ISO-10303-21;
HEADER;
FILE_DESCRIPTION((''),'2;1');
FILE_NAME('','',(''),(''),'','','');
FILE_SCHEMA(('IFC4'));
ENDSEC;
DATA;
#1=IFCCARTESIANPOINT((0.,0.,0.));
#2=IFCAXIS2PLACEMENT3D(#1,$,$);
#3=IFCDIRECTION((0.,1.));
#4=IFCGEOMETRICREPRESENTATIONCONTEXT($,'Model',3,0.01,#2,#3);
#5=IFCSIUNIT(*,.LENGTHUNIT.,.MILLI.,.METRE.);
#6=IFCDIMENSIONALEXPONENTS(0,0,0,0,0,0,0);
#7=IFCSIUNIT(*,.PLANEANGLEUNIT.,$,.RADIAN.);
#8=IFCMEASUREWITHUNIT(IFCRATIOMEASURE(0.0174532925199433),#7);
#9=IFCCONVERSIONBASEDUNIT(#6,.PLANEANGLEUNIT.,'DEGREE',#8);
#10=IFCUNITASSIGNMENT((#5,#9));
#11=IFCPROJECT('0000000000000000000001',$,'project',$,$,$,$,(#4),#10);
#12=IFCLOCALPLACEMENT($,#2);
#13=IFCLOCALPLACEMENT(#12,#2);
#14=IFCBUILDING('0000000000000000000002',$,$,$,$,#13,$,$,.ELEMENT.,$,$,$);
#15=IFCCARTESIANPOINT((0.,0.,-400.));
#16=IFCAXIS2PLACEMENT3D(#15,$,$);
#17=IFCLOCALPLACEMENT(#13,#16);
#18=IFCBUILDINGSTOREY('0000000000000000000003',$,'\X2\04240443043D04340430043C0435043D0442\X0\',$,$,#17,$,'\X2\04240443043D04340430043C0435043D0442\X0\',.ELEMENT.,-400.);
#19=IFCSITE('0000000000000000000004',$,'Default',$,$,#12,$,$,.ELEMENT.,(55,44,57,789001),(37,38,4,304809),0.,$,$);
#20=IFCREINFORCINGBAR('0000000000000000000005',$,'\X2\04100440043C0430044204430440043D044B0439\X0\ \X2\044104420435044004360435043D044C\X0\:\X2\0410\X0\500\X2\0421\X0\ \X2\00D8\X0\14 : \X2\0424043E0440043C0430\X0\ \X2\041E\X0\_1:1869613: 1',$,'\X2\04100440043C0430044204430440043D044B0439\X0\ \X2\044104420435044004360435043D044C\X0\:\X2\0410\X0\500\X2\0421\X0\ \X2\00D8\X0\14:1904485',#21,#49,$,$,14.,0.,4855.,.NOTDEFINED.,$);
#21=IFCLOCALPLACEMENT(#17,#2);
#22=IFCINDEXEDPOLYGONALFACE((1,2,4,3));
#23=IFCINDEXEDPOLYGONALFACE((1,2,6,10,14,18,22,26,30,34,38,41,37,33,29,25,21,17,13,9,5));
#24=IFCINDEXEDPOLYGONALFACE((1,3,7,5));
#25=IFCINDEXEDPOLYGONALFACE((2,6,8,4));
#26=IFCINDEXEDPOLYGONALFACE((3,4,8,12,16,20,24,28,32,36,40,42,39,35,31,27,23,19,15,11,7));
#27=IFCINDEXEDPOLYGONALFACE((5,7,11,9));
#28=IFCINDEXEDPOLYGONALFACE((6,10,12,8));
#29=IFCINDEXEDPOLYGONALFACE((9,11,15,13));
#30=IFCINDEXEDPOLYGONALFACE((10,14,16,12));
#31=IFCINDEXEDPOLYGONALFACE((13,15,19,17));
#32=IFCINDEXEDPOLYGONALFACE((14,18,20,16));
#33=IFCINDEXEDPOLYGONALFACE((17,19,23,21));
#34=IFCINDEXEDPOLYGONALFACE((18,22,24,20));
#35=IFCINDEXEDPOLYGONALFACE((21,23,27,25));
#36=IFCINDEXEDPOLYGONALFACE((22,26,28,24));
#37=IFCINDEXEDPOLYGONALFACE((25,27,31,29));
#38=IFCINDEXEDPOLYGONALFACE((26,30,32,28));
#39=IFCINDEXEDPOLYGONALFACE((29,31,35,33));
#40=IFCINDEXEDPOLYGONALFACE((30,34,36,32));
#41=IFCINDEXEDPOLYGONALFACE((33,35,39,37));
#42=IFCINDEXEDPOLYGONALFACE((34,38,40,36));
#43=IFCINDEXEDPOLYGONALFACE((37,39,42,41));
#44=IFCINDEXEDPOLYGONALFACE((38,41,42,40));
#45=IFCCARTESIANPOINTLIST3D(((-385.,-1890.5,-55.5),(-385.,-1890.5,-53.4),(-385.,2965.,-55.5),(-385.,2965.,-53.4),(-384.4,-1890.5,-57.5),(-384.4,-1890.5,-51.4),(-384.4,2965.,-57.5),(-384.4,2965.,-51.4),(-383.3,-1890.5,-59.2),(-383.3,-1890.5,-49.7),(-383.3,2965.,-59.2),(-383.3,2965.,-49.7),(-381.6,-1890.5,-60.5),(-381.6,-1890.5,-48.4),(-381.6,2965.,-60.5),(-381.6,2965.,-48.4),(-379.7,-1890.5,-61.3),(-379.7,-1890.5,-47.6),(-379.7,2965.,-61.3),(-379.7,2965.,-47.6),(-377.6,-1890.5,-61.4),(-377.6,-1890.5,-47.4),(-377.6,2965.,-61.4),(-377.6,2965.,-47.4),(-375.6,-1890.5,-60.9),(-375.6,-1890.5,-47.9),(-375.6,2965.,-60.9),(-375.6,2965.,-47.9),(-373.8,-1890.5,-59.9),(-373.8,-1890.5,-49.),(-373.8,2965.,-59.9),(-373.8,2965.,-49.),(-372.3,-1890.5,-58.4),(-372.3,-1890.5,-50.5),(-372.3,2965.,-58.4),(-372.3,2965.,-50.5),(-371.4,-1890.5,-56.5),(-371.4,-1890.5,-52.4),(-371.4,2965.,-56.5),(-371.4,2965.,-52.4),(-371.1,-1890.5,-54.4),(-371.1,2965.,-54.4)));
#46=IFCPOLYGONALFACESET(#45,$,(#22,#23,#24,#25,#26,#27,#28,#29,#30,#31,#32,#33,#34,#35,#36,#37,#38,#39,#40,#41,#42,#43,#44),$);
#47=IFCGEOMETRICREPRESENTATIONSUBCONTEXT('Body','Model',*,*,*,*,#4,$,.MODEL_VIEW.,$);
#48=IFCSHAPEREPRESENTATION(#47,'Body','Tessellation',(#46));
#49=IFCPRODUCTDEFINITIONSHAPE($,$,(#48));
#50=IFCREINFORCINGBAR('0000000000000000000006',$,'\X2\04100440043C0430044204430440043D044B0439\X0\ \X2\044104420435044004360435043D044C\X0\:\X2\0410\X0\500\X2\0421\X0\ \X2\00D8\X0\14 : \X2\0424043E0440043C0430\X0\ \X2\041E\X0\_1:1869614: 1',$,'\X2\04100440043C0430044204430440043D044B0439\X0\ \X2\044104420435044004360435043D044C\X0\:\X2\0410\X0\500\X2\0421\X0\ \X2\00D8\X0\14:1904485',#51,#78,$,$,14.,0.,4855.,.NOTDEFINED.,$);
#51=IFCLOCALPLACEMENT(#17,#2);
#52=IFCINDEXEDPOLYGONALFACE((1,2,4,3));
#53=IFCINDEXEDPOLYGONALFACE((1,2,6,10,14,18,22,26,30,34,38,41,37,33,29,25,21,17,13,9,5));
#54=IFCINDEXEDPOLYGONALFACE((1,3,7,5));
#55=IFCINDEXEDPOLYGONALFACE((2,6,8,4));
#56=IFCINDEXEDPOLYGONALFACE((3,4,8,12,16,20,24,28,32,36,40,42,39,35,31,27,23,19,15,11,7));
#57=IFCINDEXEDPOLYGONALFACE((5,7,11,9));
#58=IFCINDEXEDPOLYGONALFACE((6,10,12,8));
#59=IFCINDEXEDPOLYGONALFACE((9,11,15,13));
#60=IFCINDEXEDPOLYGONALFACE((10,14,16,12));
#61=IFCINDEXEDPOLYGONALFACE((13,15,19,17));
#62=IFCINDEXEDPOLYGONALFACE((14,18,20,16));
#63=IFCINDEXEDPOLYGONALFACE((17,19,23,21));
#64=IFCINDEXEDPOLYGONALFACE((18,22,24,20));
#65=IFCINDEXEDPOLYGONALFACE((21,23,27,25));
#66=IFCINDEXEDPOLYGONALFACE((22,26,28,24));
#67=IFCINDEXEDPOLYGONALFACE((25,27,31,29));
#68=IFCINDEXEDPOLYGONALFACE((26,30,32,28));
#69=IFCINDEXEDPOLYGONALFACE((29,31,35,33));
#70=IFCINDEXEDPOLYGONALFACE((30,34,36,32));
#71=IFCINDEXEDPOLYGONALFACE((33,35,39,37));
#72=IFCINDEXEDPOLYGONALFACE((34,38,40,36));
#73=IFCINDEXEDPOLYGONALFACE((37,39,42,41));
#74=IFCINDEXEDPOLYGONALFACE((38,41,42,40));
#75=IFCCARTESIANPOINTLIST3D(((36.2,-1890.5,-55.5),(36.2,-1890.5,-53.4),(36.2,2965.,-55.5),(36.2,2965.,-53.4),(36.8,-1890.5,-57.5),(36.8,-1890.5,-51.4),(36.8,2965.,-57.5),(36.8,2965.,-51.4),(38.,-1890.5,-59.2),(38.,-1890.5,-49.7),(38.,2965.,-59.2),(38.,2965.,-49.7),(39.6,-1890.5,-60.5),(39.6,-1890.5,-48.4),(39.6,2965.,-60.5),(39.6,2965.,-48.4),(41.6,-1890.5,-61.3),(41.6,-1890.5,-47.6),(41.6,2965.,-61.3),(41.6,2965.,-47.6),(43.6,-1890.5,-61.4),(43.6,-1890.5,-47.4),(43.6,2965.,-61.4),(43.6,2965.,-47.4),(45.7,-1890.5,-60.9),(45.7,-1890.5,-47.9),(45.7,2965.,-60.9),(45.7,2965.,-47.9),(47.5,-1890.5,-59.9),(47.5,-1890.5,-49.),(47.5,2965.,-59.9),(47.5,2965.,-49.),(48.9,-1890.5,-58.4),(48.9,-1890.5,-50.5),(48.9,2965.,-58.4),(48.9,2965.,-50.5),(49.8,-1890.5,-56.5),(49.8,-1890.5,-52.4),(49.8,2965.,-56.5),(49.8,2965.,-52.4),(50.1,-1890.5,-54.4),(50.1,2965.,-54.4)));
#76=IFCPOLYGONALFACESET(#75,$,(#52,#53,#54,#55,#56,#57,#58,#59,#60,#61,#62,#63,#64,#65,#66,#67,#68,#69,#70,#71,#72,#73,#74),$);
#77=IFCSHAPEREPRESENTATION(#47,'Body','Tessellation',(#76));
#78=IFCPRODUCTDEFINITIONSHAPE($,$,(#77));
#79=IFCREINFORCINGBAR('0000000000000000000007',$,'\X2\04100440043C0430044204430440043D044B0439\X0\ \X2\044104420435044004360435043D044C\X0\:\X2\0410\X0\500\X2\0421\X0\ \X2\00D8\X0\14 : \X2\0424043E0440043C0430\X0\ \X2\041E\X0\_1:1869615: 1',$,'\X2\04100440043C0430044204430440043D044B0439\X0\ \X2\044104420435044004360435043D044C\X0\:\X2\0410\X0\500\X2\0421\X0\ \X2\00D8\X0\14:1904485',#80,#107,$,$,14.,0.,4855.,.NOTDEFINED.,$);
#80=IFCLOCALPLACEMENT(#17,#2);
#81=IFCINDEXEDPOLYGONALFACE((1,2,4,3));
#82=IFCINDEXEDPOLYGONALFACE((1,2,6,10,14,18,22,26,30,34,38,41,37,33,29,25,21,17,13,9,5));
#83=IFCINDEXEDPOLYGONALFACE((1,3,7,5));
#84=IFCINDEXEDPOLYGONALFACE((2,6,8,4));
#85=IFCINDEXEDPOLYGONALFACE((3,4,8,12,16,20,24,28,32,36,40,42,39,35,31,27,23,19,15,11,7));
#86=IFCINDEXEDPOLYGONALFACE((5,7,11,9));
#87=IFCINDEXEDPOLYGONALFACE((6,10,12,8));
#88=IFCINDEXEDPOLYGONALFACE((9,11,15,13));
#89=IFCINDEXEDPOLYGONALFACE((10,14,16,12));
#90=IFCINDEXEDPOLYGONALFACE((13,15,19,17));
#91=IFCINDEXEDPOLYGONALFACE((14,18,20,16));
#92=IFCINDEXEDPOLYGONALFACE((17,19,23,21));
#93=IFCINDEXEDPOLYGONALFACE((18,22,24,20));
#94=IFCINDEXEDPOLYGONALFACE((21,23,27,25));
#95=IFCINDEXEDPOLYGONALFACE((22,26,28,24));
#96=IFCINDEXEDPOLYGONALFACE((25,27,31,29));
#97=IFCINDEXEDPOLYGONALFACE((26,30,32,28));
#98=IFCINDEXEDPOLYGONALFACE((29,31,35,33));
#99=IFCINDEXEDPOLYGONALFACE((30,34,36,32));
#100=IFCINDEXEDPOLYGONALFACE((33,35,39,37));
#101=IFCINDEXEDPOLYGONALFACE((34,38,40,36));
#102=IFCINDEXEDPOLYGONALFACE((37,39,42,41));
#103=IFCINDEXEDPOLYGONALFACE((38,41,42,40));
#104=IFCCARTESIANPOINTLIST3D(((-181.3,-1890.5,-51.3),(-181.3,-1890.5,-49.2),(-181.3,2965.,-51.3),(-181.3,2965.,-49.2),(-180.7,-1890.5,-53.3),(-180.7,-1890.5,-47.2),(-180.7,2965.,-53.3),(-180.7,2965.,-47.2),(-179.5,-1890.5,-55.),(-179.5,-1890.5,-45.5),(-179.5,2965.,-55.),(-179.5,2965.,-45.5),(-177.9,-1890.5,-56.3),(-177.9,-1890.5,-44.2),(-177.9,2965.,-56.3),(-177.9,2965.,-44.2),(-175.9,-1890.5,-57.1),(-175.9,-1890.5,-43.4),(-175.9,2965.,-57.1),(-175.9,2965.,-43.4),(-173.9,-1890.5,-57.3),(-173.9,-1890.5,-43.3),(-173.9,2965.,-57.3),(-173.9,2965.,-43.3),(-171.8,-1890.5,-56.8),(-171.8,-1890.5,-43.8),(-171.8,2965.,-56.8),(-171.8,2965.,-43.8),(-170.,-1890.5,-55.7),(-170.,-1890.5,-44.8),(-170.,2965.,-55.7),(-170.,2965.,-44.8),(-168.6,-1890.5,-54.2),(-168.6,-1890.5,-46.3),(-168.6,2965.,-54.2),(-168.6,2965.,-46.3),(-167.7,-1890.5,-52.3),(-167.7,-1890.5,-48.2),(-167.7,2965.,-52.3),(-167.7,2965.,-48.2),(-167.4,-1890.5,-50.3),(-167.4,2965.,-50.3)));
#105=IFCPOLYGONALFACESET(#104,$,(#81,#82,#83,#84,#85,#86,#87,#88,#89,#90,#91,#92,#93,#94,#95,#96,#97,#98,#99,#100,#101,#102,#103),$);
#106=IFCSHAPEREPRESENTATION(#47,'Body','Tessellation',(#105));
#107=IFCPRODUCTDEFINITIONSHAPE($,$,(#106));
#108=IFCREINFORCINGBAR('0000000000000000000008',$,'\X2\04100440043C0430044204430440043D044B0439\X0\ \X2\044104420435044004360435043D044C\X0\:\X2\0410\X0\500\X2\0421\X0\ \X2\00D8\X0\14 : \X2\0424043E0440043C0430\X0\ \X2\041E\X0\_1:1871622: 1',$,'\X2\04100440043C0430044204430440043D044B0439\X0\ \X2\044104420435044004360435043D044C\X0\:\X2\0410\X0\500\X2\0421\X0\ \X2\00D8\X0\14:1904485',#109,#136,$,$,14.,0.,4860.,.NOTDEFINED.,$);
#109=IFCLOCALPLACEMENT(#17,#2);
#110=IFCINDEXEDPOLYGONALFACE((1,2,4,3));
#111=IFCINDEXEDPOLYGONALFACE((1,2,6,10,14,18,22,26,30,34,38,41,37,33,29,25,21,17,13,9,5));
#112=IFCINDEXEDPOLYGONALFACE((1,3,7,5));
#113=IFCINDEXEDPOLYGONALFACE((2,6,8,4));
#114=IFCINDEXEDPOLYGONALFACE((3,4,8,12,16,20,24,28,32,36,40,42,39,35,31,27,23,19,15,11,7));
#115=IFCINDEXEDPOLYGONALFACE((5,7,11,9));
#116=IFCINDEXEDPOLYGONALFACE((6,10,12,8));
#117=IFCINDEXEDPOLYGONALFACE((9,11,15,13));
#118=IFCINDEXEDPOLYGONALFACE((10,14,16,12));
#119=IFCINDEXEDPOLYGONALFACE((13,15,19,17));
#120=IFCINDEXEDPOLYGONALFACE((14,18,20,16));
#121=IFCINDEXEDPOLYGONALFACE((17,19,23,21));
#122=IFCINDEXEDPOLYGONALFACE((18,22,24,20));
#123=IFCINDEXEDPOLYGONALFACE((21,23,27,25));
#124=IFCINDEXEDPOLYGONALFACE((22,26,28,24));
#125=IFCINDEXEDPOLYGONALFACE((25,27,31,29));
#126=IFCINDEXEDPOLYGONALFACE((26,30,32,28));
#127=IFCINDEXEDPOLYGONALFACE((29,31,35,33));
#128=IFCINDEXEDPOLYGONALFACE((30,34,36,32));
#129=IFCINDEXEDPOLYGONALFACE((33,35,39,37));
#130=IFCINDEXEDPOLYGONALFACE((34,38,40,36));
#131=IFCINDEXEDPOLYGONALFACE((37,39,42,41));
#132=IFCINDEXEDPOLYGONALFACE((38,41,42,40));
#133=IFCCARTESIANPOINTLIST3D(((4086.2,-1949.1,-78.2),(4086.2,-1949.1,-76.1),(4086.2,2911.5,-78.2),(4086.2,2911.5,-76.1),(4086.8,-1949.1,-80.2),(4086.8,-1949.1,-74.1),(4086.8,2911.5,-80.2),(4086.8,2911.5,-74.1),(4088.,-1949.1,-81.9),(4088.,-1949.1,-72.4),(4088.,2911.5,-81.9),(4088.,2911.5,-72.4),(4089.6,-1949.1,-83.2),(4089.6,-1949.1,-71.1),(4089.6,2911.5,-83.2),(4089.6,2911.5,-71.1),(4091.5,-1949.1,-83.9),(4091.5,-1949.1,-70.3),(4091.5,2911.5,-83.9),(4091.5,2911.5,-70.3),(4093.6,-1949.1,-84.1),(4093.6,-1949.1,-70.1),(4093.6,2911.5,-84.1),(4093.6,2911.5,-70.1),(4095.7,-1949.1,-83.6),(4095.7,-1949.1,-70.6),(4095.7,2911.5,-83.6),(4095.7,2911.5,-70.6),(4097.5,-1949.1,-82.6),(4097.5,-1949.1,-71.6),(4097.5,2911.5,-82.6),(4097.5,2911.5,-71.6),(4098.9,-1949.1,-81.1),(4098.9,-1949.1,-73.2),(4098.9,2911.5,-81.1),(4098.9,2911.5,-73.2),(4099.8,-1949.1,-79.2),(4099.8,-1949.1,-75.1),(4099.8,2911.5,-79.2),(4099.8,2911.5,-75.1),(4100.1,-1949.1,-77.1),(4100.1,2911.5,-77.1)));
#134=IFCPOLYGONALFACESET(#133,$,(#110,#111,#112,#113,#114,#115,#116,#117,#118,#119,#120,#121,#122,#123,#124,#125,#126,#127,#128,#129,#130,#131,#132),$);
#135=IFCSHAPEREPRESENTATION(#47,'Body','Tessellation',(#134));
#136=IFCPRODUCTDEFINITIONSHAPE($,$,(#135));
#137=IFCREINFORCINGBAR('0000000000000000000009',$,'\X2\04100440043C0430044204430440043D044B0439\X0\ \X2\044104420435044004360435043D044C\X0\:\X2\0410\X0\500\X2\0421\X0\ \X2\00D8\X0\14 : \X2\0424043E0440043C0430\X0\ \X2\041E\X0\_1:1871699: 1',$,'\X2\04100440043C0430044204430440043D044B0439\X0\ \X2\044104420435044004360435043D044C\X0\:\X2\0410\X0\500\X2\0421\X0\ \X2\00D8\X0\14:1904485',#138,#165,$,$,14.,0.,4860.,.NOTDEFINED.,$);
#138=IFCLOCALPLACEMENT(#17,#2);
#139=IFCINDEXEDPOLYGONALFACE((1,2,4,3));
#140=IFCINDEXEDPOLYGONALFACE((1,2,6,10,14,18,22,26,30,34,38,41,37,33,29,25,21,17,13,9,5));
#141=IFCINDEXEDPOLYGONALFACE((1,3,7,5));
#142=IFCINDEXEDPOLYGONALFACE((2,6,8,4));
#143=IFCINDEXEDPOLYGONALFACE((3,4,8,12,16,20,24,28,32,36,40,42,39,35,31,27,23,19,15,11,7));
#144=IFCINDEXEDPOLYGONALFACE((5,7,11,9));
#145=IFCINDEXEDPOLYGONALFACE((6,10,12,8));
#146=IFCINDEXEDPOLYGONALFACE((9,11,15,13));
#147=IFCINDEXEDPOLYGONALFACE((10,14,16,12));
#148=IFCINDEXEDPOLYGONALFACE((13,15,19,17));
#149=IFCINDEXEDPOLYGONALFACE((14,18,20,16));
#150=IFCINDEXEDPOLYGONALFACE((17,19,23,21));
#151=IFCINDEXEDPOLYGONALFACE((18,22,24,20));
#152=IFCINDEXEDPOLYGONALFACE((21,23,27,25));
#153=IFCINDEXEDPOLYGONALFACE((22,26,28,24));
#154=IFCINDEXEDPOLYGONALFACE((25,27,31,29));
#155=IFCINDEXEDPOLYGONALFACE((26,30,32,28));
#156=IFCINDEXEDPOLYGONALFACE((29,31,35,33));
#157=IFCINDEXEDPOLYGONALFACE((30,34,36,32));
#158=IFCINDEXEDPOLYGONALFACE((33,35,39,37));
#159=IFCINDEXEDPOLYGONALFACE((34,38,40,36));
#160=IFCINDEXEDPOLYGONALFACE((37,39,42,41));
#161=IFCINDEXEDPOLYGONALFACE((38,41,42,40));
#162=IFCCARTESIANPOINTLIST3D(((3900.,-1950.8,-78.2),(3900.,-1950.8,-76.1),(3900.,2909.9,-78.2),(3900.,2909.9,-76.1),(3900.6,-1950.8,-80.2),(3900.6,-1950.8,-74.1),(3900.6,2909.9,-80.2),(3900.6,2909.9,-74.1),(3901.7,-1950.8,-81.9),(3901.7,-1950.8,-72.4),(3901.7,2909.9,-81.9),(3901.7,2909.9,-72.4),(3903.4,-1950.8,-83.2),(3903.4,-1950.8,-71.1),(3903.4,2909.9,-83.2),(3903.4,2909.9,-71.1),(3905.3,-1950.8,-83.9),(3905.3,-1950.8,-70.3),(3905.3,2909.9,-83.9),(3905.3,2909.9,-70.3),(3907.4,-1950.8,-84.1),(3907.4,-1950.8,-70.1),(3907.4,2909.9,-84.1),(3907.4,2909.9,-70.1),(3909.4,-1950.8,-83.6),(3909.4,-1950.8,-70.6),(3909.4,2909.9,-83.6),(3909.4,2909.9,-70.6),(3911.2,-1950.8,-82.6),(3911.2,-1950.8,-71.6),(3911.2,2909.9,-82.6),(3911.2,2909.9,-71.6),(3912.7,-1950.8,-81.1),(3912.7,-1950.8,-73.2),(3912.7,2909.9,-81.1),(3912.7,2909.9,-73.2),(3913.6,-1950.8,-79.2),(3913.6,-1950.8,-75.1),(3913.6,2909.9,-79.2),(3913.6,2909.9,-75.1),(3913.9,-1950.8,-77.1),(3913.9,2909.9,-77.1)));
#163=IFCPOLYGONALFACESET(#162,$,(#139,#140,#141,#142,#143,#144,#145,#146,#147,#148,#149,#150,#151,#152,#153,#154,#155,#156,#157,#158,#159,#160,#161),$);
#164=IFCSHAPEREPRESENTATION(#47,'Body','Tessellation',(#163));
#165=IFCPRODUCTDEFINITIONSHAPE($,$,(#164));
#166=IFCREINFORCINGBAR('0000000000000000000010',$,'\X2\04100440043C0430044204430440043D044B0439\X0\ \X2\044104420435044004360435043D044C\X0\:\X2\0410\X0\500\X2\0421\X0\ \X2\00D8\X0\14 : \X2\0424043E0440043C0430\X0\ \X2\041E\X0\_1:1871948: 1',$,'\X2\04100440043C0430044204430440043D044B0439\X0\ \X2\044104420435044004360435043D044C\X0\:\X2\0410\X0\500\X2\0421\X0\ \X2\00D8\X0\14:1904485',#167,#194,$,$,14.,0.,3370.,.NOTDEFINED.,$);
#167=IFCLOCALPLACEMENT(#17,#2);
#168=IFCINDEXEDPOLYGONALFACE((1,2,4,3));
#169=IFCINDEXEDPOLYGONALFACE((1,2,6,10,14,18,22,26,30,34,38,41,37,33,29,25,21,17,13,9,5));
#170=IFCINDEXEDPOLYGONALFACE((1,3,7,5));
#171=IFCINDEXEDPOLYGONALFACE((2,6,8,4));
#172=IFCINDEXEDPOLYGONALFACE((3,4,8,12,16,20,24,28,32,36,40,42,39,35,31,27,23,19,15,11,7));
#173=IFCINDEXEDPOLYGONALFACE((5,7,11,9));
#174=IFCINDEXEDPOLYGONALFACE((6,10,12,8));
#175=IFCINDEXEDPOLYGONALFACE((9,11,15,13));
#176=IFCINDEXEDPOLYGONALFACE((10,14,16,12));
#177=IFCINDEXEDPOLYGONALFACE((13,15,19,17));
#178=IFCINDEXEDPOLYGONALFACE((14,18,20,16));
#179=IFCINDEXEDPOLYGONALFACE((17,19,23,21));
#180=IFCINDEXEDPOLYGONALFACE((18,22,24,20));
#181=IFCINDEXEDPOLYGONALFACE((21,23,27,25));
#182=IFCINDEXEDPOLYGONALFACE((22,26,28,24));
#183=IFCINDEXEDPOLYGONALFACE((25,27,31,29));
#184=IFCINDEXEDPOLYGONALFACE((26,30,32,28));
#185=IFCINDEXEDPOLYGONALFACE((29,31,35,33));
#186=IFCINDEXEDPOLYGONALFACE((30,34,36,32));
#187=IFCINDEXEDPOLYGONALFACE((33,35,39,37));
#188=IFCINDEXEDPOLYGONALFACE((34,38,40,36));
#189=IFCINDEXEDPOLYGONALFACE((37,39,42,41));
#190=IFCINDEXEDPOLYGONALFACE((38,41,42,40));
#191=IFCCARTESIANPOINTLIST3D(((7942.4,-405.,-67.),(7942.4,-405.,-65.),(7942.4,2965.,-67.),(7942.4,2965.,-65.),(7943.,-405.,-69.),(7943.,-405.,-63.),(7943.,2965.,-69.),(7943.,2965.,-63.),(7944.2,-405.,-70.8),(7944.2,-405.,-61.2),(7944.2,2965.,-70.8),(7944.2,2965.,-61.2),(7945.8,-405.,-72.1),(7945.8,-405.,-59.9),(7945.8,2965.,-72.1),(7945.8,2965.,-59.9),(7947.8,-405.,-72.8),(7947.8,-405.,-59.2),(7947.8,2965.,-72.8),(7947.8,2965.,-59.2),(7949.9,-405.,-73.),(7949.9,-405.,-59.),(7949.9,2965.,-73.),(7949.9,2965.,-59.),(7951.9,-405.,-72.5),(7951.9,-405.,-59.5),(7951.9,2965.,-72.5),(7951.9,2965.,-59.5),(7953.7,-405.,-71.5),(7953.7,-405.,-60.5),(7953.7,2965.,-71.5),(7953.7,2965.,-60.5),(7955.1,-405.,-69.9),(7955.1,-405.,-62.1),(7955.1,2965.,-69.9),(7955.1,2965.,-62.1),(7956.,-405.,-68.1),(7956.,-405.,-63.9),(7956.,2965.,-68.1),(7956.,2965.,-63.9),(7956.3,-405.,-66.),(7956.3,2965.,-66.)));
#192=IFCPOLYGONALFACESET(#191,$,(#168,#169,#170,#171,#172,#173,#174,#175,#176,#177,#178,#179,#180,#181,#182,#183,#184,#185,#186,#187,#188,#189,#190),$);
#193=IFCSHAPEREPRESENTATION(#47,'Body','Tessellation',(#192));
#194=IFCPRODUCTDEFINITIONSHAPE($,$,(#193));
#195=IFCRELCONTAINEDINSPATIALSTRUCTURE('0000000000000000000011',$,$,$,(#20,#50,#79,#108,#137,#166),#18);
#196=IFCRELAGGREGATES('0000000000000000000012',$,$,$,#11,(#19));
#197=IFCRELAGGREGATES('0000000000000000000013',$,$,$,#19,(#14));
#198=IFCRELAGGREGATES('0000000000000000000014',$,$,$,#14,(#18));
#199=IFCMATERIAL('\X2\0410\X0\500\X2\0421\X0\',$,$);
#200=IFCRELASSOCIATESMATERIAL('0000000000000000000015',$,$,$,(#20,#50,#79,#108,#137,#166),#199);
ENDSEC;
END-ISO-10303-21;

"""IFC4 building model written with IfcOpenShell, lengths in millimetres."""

from ifc_helpers import new_model, entity, si_unit, converted_unit, direction, frame, origin, place, context, subcontext, project, spatial, material, element, save


model = new_model("IFC4")

# Units and contexts
model_context = context("Model", 3, precision=0.01, world=origin(), true_north=direction((0.0, 1.0)))
body_context = subcontext(model_context, "Body", "Model", "MODEL_VIEW")
ifc_project = project(units=[si_unit("LENGTHUNIT", "METRE", prefix="MILLI"), converted_unit("PLANEANGLEUNIT", "DEGREE", entity("IfcRatioMeasure", 0.0174532925199433), si_unit("PLANEANGLEUNIT", "RADIAN"), dimensions=[0, 0, 0, 0, 0, 0, 0])], contexts=[model_context])

# Site, building, storey
site_placement = place(None, origin())
site = spatial("IfcSite", under=ifc_project, at=site_placement, Name="Default", CompositionType="ELEMENT", RefLatitude=(55, 44, 57, 789001), RefLongitude=(37, 38, 4, 304809), RefElevation=0.0)
building_placement = place(site_placement, origin())
building = spatial("IfcBuilding", under=site, at=building_placement, CompositionType="ELEMENT")
storey_placement = place(building_placement, frame((0.0, 0.0, -400.0)))
storey = spatial("IfcBuildingStorey", under=building, at=storey_placement, Name="Фундамент", LongName="Фундамент", CompositionType="ELEMENT", Elevation=-400.0)

# Reinforcing bars
ifc_material_1 = material(Name="А500С")
reinforcing_bar_1_placement = place(storey_placement, origin())
element("IfcReinforcingBar", 1, at=reinforcing_bar_1_placement, inside=storey, material=ifc_material_1, Name="Арматурный стержень:А500С Ø14 : Форма О_1:1869613: 1", ObjectType="Арматурный стержень:А500С Ø14:1904485", BarLength=4855.0, CrossSectionArea=0.0, NominalDiameter=14.0, PredefinedType="NOTDEFINED", context=body_context, shape_type="AdvancedSweptSolid", body=[
    entity("IfcSweptDiskSolid", entity("IfcCompositeCurve", [entity("IfcCompositeCurveSegment", "CONTINUOUS", True, entity("IfcPolyline", [entity("IfcCartesianPoint", [-378.1, -1890.5, -54.4]), entity("IfcCartesianPoint", [-378.1, 2965.0, -54.4])]))], False), 7.0, None, 0.0, 1.0),
])
reinforcing_bar_2_placement = place(storey_placement, origin())
element("IfcReinforcingBar", 2, at=reinforcing_bar_2_placement, inside=storey, material=ifc_material_1, Name="Арматурный стержень:А500С Ø14 : Форма О_1:1869614: 1", ObjectType="Арматурный стержень:А500С Ø14:1904485", BarLength=4855.0, CrossSectionArea=0.0, NominalDiameter=14.0, PredefinedType="NOTDEFINED", context=body_context, shape_type="AdvancedSweptSolid", body=[
    entity("IfcSweptDiskSolid", entity("IfcCompositeCurve", [entity("IfcCompositeCurveSegment", "CONTINUOUS", True, entity("IfcPolyline", [entity("IfcCartesianPoint", [43.1, -1890.5, -54.4]), entity("IfcCartesianPoint", [43.1, 2965.0, -54.4])]))], False), 7.0, None, 0.0, 1.0),
])
reinforcing_bar_3_placement = place(storey_placement, origin())
element("IfcReinforcingBar", 3, at=reinforcing_bar_3_placement, inside=storey, material=ifc_material_1, Name="Арматурный стержень:А500С Ø14 : Форма О_1:1869615: 1", ObjectType="Арматурный стержень:А500С Ø14:1904485", BarLength=4855.0, CrossSectionArea=0.0, NominalDiameter=14.0, PredefinedType="NOTDEFINED", context=body_context, shape_type="AdvancedSweptSolid", body=[
    entity("IfcSweptDiskSolid", entity("IfcCompositeCurve", [entity("IfcCompositeCurveSegment", "CONTINUOUS", True, entity("IfcPolyline", [entity("IfcCartesianPoint", [-174.4, -1890.5, -50.3]), entity("IfcCartesianPoint", [-174.4, 2965.0, -50.3])]))], False), 7.0, None, 0.0, 1.0),
])
reinforcing_bar_4_placement = place(storey_placement, origin())
element("IfcReinforcingBar", 4, at=reinforcing_bar_4_placement, inside=storey, material=ifc_material_1, Name="Арматурный стержень:А500С Ø14 : Форма О_1:1871622: 1", ObjectType="Арматурный стержень:А500С Ø14:1904485", BarLength=4860.0, CrossSectionArea=0.0, NominalDiameter=14.0, PredefinedType="NOTDEFINED", context=body_context, shape_type="AdvancedSweptSolid", body=[
    entity("IfcSweptDiskSolid", entity("IfcCompositeCurve", [entity("IfcCompositeCurveSegment", "CONTINUOUS", True, entity("IfcPolyline", [entity("IfcCartesianPoint", [4093.1, -1949.1, -77.1]), entity("IfcCartesianPoint", [4093.1, 2911.5, -77.1])]))], False), 7.0, None, 0.0, 1.0),
])
reinforcing_bar_5_placement = place(storey_placement, origin())
element("IfcReinforcingBar", 5, at=reinforcing_bar_5_placement, inside=storey, material=ifc_material_1, Name="Арматурный стержень:А500С Ø14 : Форма О_1:1871699: 1", ObjectType="Арматурный стержень:А500С Ø14:1904485", BarLength=4860.0, CrossSectionArea=0.0, NominalDiameter=14.0, PredefinedType="NOTDEFINED", context=body_context, shape_type="AdvancedSweptSolid", body=[
    entity("IfcSweptDiskSolid", entity("IfcCompositeCurve", [entity("IfcCompositeCurveSegment", "CONTINUOUS", True, entity("IfcPolyline", [entity("IfcCartesianPoint", [3906.9, -1950.8, -77.1]), entity("IfcCartesianPoint", [3906.9, 2909.9, -77.1])]))], False), 7.0, None, 0.0, 1.0),
])
reinforcing_bar_6_placement = place(storey_placement, origin())
element("IfcReinforcingBar", 6, at=reinforcing_bar_6_placement, inside=storey, material=ifc_material_1, Name="Арматурный стержень:А500С Ø14 : Форма О_1:1871948: 1", ObjectType="Арматурный стержень:А500С Ø14:1904485", BarLength=3370.0, CrossSectionArea=0.0, NominalDiameter=14.0, PredefinedType="NOTDEFINED", context=body_context, shape_type="AdvancedSweptSolid", body=[
    entity("IfcSweptDiskSolid", entity("IfcCompositeCurve", [entity("IfcCompositeCurveSegment", "CONTINUOUS", True, entity("IfcPolyline", [entity("IfcCartesianPoint", [7949.3, -405.0, -66.0]), entity("IfcCartesianPoint", [7949.3, 2965.0, -66.0])]))], False), 7.0, None, 0.0, 1.0),
])

save(model, "model.ifc")
